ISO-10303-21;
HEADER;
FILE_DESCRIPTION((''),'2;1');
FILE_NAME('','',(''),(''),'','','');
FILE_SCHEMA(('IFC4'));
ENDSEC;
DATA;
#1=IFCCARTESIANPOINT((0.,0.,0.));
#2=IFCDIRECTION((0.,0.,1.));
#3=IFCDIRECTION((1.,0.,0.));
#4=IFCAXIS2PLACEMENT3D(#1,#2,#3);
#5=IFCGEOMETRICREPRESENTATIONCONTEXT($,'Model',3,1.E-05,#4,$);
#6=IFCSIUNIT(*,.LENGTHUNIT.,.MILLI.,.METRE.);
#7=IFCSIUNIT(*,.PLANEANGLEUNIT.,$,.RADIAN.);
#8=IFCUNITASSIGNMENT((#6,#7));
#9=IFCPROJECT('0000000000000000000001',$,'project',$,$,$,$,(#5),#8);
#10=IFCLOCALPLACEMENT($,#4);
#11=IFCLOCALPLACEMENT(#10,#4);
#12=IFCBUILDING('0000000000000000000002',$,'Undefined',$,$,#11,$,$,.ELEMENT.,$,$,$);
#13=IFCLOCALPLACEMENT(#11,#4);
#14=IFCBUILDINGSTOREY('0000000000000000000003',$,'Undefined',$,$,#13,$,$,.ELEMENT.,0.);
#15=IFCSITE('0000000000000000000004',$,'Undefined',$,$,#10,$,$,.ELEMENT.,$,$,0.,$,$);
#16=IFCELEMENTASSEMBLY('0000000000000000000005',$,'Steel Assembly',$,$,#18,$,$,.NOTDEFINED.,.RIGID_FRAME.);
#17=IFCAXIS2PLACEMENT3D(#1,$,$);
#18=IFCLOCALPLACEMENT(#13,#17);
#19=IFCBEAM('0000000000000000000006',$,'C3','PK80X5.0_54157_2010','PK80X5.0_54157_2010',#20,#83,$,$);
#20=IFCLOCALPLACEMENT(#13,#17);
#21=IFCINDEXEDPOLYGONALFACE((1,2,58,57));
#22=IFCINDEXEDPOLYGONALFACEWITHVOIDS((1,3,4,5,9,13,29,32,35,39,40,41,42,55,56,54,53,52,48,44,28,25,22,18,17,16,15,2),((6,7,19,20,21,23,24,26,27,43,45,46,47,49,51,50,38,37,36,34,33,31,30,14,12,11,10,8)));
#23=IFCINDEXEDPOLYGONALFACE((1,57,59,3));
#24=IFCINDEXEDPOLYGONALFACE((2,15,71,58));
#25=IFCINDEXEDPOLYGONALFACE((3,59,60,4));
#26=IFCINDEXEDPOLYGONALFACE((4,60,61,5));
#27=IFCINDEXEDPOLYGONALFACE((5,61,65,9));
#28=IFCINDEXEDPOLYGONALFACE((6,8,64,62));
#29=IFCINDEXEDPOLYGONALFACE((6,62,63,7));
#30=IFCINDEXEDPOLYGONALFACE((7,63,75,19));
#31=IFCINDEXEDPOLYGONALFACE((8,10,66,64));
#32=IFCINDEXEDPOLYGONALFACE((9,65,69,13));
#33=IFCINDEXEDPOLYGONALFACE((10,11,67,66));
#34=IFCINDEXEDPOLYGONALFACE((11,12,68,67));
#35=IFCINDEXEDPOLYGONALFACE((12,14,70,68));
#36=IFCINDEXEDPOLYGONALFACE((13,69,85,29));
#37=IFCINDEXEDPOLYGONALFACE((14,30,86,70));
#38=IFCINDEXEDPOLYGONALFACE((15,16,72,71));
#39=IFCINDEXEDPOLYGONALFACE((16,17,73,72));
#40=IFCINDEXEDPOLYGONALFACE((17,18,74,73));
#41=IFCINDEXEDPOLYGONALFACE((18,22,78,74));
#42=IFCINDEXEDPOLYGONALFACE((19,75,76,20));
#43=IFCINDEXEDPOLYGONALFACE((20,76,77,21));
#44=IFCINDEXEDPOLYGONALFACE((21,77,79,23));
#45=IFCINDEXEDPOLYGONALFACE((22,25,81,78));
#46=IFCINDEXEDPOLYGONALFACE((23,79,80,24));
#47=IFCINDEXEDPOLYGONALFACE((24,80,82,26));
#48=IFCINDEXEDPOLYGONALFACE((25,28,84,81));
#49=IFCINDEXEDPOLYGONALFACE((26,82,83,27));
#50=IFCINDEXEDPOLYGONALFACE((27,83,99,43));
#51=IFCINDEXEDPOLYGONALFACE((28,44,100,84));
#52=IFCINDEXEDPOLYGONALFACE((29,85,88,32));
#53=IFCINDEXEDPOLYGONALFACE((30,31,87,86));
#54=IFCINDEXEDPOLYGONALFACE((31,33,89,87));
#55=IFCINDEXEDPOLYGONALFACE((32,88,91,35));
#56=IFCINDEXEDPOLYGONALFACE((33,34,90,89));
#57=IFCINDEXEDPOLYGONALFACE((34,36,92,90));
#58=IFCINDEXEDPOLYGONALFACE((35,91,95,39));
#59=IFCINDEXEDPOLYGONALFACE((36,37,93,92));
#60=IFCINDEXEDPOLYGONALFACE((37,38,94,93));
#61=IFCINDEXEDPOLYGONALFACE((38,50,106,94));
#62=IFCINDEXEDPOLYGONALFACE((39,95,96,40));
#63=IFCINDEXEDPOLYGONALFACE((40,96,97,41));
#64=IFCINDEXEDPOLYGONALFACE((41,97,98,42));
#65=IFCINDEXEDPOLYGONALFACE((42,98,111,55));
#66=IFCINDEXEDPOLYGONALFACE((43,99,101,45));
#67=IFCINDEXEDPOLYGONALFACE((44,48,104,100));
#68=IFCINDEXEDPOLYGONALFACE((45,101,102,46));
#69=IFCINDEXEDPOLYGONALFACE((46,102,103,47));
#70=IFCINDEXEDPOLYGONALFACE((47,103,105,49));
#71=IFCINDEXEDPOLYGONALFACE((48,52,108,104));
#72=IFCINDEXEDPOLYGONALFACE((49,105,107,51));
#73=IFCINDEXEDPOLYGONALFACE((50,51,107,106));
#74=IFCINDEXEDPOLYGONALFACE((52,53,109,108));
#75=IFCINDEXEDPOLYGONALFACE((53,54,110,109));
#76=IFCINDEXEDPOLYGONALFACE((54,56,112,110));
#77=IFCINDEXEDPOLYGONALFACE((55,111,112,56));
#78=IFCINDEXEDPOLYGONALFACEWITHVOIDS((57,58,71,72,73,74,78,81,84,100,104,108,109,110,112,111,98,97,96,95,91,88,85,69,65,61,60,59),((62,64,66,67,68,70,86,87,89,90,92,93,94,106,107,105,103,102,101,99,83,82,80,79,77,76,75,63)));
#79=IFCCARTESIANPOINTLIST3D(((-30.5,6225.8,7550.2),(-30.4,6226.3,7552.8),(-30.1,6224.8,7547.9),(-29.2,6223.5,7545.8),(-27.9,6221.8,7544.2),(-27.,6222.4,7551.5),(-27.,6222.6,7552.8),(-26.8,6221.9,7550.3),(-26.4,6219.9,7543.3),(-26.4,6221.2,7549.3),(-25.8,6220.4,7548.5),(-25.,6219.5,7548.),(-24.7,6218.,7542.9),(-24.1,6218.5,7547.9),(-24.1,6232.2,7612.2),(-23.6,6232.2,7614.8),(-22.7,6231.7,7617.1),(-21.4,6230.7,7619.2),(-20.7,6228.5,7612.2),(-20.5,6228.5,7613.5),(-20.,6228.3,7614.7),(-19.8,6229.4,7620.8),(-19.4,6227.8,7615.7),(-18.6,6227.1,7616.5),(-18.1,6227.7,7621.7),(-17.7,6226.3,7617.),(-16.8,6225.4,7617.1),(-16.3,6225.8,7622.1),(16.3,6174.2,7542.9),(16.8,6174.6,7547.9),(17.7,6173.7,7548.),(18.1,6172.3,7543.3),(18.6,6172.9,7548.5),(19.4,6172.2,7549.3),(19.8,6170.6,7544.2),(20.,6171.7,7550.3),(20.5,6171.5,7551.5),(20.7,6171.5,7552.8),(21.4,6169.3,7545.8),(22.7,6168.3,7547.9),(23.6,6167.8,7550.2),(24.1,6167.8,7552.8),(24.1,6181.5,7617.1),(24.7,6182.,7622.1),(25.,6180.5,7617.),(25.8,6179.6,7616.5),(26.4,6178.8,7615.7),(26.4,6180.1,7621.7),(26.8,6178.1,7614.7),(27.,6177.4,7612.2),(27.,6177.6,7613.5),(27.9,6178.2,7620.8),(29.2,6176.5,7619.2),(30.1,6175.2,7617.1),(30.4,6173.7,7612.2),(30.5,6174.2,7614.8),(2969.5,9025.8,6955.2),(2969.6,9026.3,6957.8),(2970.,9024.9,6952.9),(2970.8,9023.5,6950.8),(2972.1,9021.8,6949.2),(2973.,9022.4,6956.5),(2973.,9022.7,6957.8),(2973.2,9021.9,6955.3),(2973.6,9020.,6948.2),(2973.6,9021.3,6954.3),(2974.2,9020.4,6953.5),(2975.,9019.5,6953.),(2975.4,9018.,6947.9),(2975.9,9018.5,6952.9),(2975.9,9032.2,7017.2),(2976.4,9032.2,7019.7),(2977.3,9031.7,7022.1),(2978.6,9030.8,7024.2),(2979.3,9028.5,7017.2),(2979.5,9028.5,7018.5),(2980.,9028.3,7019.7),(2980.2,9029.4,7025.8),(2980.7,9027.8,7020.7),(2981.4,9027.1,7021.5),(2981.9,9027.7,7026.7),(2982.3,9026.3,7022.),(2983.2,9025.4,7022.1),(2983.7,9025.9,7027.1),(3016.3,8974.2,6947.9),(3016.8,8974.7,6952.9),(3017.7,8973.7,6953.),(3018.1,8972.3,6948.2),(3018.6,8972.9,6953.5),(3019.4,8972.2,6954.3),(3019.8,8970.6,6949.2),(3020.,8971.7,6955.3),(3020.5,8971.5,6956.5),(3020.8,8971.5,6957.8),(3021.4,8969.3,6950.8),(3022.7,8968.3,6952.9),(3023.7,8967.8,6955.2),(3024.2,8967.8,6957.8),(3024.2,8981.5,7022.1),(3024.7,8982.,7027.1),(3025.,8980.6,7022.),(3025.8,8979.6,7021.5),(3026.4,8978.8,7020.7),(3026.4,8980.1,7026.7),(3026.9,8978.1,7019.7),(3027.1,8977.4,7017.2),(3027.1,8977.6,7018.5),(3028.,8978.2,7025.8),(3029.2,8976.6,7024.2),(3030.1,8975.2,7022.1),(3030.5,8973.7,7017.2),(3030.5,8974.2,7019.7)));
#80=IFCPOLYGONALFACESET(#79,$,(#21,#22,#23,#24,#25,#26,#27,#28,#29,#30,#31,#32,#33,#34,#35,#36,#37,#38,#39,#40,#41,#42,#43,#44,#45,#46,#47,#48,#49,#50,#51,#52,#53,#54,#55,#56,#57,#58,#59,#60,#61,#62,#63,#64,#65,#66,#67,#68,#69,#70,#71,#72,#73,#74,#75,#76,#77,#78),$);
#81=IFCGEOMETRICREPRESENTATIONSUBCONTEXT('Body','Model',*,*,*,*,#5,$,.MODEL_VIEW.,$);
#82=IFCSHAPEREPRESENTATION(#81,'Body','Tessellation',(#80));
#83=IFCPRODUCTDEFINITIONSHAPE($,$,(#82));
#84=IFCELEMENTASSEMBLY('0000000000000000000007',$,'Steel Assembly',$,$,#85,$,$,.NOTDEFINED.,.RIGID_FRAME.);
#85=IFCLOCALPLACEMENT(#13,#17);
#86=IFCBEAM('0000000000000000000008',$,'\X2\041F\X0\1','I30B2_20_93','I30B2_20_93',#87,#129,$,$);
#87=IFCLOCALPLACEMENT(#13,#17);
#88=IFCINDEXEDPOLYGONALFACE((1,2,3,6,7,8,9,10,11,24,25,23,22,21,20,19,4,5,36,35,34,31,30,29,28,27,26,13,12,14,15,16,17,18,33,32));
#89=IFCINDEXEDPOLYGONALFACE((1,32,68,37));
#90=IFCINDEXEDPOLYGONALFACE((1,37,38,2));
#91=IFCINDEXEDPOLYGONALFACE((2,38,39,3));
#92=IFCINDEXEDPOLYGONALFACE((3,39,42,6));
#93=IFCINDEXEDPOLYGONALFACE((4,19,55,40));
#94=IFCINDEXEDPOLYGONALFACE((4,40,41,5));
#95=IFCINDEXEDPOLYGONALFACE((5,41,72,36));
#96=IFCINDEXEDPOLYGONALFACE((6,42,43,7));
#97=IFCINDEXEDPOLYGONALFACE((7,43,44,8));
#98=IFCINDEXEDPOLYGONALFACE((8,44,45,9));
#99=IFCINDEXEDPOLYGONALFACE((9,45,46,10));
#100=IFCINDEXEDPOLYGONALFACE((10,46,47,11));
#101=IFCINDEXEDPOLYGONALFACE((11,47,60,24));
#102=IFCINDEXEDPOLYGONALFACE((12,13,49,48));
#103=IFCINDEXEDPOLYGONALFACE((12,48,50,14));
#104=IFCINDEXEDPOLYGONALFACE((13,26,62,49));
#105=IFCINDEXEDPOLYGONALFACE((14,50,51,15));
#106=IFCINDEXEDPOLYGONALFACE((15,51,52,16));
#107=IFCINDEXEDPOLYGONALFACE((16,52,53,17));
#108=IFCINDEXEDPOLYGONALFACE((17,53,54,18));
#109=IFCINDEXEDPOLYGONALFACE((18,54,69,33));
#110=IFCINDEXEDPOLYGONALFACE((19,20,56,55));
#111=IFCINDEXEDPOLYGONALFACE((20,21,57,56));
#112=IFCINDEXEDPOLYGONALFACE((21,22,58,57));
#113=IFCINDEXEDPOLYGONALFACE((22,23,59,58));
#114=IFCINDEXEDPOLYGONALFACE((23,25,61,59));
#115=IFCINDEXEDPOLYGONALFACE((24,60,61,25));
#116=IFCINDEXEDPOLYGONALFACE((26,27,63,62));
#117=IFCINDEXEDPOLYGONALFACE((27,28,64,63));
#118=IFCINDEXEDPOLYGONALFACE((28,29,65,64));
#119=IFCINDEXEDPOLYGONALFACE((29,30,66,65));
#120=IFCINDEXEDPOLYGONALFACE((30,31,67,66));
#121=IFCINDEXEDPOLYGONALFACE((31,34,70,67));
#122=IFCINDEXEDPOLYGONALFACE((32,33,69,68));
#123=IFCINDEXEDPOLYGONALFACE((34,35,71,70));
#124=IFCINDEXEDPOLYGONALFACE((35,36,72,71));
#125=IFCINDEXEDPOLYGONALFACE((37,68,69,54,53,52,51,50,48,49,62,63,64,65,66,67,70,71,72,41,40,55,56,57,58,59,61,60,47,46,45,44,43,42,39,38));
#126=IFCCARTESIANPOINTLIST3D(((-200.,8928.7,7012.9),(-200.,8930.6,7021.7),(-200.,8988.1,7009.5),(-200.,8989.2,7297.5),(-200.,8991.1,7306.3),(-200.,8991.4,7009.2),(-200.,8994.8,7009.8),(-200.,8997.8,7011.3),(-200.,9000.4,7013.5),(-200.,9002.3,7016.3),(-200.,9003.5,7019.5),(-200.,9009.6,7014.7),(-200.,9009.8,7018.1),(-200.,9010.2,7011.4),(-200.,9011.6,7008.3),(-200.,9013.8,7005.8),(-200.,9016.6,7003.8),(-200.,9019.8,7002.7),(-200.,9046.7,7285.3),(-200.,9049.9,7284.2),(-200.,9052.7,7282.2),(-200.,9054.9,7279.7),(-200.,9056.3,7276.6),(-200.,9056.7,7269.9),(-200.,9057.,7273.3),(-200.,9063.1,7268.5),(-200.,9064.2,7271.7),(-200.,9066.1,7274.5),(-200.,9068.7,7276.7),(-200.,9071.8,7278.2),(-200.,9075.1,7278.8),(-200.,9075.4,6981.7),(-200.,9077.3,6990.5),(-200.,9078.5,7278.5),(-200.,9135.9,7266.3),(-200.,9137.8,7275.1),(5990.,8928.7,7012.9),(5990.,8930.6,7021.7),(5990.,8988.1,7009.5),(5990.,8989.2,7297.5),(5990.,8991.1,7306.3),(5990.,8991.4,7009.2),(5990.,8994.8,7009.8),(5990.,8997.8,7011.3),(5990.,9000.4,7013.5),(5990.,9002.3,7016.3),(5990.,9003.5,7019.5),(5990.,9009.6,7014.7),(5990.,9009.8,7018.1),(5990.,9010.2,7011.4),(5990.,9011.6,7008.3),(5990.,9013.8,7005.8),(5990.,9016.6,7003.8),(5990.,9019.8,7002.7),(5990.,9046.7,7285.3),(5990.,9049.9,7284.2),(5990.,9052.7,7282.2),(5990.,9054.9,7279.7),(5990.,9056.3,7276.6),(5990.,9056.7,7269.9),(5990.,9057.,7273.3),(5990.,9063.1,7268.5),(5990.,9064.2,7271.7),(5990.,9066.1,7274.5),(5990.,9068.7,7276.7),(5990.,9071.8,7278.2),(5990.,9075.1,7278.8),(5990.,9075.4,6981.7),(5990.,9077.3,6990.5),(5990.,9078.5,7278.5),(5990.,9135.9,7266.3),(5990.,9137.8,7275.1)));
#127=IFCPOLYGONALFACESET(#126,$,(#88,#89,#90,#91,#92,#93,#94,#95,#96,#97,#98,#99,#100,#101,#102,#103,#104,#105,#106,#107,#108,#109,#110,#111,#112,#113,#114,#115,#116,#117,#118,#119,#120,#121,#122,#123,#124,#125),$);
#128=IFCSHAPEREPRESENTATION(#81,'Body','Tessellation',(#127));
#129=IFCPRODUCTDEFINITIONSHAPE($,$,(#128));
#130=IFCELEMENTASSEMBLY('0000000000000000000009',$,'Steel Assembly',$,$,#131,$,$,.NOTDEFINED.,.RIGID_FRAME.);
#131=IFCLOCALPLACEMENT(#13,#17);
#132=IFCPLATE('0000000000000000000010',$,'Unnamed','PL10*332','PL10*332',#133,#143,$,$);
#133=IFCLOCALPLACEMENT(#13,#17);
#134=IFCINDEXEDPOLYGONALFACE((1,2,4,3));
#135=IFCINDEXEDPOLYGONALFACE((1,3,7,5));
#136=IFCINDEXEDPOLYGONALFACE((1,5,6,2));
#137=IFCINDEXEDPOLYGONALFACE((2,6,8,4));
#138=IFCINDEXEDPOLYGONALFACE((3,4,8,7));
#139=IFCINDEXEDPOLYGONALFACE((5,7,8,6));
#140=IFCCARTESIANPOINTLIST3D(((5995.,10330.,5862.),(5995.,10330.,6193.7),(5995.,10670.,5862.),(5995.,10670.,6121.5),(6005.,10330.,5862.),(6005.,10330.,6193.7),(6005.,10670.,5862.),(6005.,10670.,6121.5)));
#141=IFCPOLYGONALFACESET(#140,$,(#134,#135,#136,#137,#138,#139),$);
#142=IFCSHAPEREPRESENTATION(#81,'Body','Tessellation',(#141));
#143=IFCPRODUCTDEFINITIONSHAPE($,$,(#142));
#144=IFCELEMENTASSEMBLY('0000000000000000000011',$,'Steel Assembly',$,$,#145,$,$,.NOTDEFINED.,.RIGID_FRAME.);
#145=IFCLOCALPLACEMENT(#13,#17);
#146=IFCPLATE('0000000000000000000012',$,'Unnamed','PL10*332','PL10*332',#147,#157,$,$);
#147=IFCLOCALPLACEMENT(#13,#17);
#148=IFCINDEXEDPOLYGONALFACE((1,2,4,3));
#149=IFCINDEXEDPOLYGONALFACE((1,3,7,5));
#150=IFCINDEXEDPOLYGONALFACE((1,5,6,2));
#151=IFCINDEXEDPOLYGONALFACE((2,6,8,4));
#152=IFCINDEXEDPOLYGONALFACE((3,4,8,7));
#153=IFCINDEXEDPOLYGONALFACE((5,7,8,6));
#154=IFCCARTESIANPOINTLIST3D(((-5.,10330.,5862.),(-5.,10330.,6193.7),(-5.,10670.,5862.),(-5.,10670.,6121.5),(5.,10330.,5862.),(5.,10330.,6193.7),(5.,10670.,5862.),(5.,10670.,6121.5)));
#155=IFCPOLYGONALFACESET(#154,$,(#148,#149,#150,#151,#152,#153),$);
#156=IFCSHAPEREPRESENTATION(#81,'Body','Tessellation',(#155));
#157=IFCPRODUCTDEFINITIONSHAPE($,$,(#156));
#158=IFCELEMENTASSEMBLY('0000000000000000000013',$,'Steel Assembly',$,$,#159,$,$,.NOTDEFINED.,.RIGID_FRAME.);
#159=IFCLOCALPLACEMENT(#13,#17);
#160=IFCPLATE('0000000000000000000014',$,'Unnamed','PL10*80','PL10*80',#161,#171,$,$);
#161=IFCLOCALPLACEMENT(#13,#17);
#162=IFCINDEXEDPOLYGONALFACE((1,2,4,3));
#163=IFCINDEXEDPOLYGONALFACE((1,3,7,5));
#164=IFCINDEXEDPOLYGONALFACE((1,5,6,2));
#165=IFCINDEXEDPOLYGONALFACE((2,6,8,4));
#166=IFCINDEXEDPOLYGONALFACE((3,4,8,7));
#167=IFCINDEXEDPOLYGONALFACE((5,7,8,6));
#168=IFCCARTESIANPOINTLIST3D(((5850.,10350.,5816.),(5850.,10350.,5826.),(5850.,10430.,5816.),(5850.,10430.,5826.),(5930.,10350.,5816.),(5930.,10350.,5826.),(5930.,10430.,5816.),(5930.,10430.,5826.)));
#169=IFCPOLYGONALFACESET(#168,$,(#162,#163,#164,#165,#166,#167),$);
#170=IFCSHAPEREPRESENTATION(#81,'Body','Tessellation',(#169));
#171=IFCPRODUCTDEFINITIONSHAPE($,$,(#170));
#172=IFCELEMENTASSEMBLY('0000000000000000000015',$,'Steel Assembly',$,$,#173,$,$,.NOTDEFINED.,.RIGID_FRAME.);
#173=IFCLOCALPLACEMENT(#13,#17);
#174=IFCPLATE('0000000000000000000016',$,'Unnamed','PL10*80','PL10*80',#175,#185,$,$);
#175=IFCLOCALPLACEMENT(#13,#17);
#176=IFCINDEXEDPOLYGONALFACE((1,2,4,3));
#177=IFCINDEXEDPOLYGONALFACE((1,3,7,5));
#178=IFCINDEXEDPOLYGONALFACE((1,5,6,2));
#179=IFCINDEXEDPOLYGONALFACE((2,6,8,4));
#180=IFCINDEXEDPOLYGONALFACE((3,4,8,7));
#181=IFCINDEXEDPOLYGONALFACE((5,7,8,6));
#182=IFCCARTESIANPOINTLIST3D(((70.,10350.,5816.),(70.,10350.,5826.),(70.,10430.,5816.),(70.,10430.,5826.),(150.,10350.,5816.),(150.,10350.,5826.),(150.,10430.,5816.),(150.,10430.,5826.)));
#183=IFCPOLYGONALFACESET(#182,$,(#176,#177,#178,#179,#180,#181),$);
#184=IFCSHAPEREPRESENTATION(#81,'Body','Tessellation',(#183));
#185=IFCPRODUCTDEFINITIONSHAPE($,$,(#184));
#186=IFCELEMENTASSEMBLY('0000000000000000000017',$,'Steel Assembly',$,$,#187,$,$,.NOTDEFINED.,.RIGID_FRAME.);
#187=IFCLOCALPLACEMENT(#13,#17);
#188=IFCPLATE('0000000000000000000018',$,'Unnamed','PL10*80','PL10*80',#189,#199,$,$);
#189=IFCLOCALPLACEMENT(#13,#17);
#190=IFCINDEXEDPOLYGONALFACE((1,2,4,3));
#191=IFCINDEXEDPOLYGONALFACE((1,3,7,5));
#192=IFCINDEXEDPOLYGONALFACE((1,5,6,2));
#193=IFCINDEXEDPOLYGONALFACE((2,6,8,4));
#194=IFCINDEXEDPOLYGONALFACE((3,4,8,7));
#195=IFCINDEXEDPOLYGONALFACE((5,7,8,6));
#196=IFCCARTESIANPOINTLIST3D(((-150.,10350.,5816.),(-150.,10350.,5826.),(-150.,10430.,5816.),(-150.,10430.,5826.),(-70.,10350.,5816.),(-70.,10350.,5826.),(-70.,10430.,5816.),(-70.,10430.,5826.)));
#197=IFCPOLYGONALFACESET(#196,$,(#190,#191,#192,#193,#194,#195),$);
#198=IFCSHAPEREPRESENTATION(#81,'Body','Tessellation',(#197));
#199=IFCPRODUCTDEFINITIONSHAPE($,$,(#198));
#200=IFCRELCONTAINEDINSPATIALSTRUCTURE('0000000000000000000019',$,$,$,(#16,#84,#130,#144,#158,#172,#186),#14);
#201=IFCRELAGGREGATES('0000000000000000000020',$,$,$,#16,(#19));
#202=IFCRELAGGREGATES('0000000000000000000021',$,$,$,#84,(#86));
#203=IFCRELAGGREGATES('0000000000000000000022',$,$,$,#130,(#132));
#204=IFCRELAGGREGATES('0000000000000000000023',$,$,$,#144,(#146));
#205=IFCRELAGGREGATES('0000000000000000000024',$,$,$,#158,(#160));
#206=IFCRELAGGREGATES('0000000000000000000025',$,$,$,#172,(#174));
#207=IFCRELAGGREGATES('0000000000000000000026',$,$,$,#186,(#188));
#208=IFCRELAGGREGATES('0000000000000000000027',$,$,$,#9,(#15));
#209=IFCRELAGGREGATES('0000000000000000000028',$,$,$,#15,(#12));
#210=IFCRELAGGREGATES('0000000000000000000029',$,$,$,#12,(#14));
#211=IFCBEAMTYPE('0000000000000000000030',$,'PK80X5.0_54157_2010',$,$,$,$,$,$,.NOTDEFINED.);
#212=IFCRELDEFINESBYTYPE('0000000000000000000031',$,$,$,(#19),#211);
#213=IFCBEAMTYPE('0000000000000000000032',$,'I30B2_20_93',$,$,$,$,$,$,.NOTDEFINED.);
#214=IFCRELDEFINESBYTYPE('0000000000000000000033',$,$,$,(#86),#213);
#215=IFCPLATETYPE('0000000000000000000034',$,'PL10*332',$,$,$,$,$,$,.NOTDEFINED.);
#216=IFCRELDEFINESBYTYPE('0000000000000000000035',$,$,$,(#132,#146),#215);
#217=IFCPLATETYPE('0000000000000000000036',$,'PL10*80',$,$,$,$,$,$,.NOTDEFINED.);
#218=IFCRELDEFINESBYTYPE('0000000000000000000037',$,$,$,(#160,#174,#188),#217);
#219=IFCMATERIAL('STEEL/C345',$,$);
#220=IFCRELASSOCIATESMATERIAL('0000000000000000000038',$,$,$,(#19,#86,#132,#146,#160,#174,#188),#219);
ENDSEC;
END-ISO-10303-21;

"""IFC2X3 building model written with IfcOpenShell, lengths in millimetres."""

from ifc_helpers import new_model, si_unit, frame, origin_with_axes, origin_2d_with_axis, place, context, subcontext, project, spatial, polyline, hollow_rectangle, i_section, outline, extrude, material, type_object, element, aggregate, save


model = new_model("IFC2X3")

# Units and contexts
model_context = context("Model", 3, precision=1e-05, world=origin_with_axes())
body_context = subcontext(model_context, "Body", "Model", "MODEL_VIEW")
ifc_project = project(units=[si_unit("LENGTHUNIT", "METRE", prefix="MILLI"), si_unit("PLANEANGLEUNIT", "RADIAN")], contexts=[model_context])

# Site, building, storey
site_placement = place(None, origin_with_axes())
site = spatial("IfcSite", under=ifc_project, at=site_placement, Name="Undefined", CompositionType="ELEMENT", RefElevation=0.0)
building_placement = place(site_placement, origin_with_axes())
building = spatial("IfcBuilding", under=site, at=building_placement, Name="Undefined", CompositionType="ELEMENT")
storey_placement = place(building_placement, origin_with_axes())
storey = spatial("IfcBuildingStorey", under=building, at=storey_placement, Name="Undefined", CompositionType="ELEMENT", Elevation=0.0)

# Element assemblies, beams
ifc_material_1 = material(Name="STEEL/C345")
beam_type_1 = type_object("IfcBeamType", Name="PK80X5.0_54157_2010", PredefinedType="NOTDEFINED")
assembly_1_placement = place(storey_placement, origin_with_axes())
assembly_1 = element("IfcElementAssembly", 1, at=assembly_1_placement, inside=storey, Name="Steel Assembly", AssemblyPlace="NOTDEFINED", PredefinedType="RIGID_FRAME")
beam_1_placement = place(assembly_1_placement, frame((3000.0, 9000.0, 6987.5), z_axis=(0.104901, 0.097907, 0.989651), x_axis=(-0.72349, -0.675257, 0.143492)))
beam_1 = element("IfcBeam", 2, at=beam_1_placement, type_object=beam_type_1, material=ifc_material_1, Name="C3", Description="PK80X5.0_54157_2010", ObjectType="PK80X5.0_54157_2010", context=body_context, shape_type="SweptSolid", body=[
    extrude(hollow_rectangle(XDim=80.0, YDim=80.0, WallThickness=5.0, InnerFilletRadius=5.0, OuterFilletRadius=10.0, at=origin_2d_with_axis()), frame((4146.6, 0.0, 0.0), z_axis=(-1.0, 0.0, 0.0), x_axis=(0.0, -1.0, 0.0)), (0.0, 0.0, 1.0), 4146.6),
])
aggregate(assembly_1, [beam_1])
assembly_2_placement = place(storey_placement, origin_with_axes())
assembly_2 = element("IfcElementAssembly", 3, at=assembly_2_placement, inside=storey, Name="Steel Assembly", AssemblyPlace="NOTDEFINED", PredefinedType="RIGID_FRAME")
beam_type_2 = type_object("IfcBeamType", Name="I30B2_20_93", PredefinedType="NOTDEFINED")
beam_2_placement = place(assembly_2_placement, frame((5990.0, 9033.3, 7144.0), z_axis=(0.0, -0.207912, -0.978148), x_axis=(-1.0, 0.0, 0.0)))
beam_2 = element("IfcBeam", 4, at=beam_2_placement, type_object=beam_type_2, material=ifc_material_1, Name="П1", Description="I30B2_20_93", ObjectType="I30B2_20_93", context=body_context, shape_type="SweptSolid", body=[
    extrude(i_section(OverallWidth=150.0, OverallDepth=300.0, WebThickness=6.5, FlangeThickness=9.0, FilletRadius=13.0, at=origin_2d_with_axis()), frame((6190.0, 0.0, 0.0), z_axis=(-1.0, 0.0, 0.0), x_axis=(0.0, -1.0, 0.0)), (0.0, 0.0, 1.0), 6190.0),
])
aggregate(assembly_2, [beam_2])

# Element assemblies, plates
assembly_3_placement = place(storey_placement, origin_with_axes())
assembly_3 = element("IfcElementAssembly", 5, at=assembly_3_placement, inside=storey, Name="Steel Assembly", AssemblyPlace="NOTDEFINED", PredefinedType="RIGID_FRAME")
plate_type_1 = type_object("IfcPlateType", Name="PL10*332", PredefinedType="NOTDEFINED")
plate_1_placement = place(assembly_3_placement, frame((6000.0, 10330.0, 5862.0), z_axis=(1.0, 0.0, 0.0), x_axis=(0.0, 1.0, 0.0)))
plate_1 = element("IfcPlate", 6, at=plate_1_placement, type_object=plate_type_1, material=ifc_material_1, Name="Unnamed", Description="PL10*332", ObjectType="PL10*332", context=body_context, shape_type="SweptSolid", body=[
    extrude(outline(polyline([(0.0, 0.0), (340.0, 0.0), (340.0, 259.5), (0.0, 331.7), (0.0, 0.0)])), frame((0.0, 0.0, -5.0), z_axis=(0.0, 0.0, 1.0), x_axis=(1.0, 0.0, 0.0)), (0.0, 0.0, 1.0), 10.0),
])
aggregate(assembly_3, [plate_1])
assembly_4_placement = place(storey_placement, origin_with_axes())
assembly_4 = element("IfcElementAssembly", 7, at=assembly_4_placement, inside=storey, Name="Steel Assembly", AssemblyPlace="NOTDEFINED", PredefinedType="RIGID_FRAME")
plate_2_placement = place(assembly_4_placement, frame((0.0, 10330.0, 5862.0), z_axis=(1.0, 0.0, 0.0), x_axis=(0.0, 1.0, 0.0)))
plate_2 = element("IfcPlate", 8, at=plate_2_placement, type_object=plate_type_1, material=ifc_material_1, Name="Unnamed", Description="PL10*332", ObjectType="PL10*332", context=body_context, shape_type="SweptSolid", body=[
    extrude(outline(polyline([(0.0, 0.0), (340.0, 0.0), (340.0, 259.5), (0.0, 331.7), (0.0, 0.0)])), frame((0.0, 0.0, -5.0), z_axis=(0.0, 0.0, 1.0), x_axis=(1.0, 0.0, 0.0)), (0.0, 0.0, 1.0), 10.0),
])
aggregate(assembly_4, [plate_2])
assembly_5_placement = place(storey_placement, origin_with_axes())
assembly_5 = element("IfcElementAssembly", 9, at=assembly_5_placement, inside=storey, Name="Steel Assembly", AssemblyPlace="NOTDEFINED", PredefinedType="RIGID_FRAME")
plate_type_2 = type_object("IfcPlateType", Name="PL10*80", PredefinedType="NOTDEFINED")
plate_3_placement = place(assembly_5_placement, frame((5850.0, 10350.0, 5821.0), z_axis=(0.0, 0.0, -1.0), x_axis=(0.0, 1.0, 0.0)))
plate_3 = element("IfcPlate", 10, at=plate_3_placement, type_object=plate_type_2, material=ifc_material_1, Name="Unnamed", Description="PL10*80", ObjectType="PL10*80", context=body_context, shape_type="SweptSolid", body=[
    extrude(outline(polyline([(0.0, 0.0), (80.0, 0.0), (80.0, 80.0), (0.0, 80.0), (0.0, 0.0)])), frame((0.0, 0.0, -5.0), z_axis=(0.0, 0.0, 1.0), x_axis=(1.0, 0.0, 0.0)), (0.0, 0.0, 1.0), 10.0),
])
aggregate(assembly_5, [plate_3])
assembly_6_placement = place(storey_placement, origin_with_axes())
assembly_6 = element("IfcElementAssembly", 11, at=assembly_6_placement, inside=storey, Name="Steel Assembly", AssemblyPlace="NOTDEFINED", PredefinedType="RIGID_FRAME")
plate_4_placement = place(assembly_6_placement, frame((150.0, 10350.0, 5821.0), z_axis=(0.0, 0.0, 1.0), x_axis=(0.0, 1.0, 0.0)))
plate_4 = element("IfcPlate", 12, at=plate_4_placement, type_object=plate_type_2, material=ifc_material_1, Name="Unnamed", Description="PL10*80", ObjectType="PL10*80", context=body_context, shape_type="SweptSolid", body=[
    extrude(outline(polyline([(0.0, 0.0), (80.0, 0.0), (80.0, 80.0), (0.0, 80.0), (0.0, 0.0)])), frame((0.0, 0.0, -5.0), z_axis=(0.0, 0.0, 1.0), x_axis=(1.0, 0.0, 0.0)), (0.0, 0.0, 1.0), 10.0),
])
aggregate(assembly_6, [plate_4])
assembly_7_placement = place(storey_placement, origin_with_axes())
assembly_7 = element("IfcElementAssembly", 13, at=assembly_7_placement, inside=storey, Name="Steel Assembly", AssemblyPlace="NOTDEFINED", PredefinedType="RIGID_FRAME")
plate_5_placement = place(assembly_7_placement, frame((-150.0, 10350.0, 5821.0), z_axis=(0.0, 0.0, -1.0), x_axis=(0.0, 1.0, 0.0)))
plate_5 = element("IfcPlate", 14, at=plate_5_placement, type_object=plate_type_2, material=ifc_material_1, Name="Unnamed", Description="PL10*80", ObjectType="PL10*80", context=body_context, shape_type="SweptSolid", body=[
    extrude(outline(polyline([(0.0, 0.0), (80.0, 0.0), (80.0, 80.0), (0.0, 80.0), (0.0, 0.0)])), frame((0.0, 0.0, -5.0), z_axis=(0.0, 0.0, 1.0), x_axis=(1.0, 0.0, 0.0)), (0.0, 0.0, 1.0), 10.0),
])
aggregate(assembly_7, [plate_5])

save(model, "model.ifc")
